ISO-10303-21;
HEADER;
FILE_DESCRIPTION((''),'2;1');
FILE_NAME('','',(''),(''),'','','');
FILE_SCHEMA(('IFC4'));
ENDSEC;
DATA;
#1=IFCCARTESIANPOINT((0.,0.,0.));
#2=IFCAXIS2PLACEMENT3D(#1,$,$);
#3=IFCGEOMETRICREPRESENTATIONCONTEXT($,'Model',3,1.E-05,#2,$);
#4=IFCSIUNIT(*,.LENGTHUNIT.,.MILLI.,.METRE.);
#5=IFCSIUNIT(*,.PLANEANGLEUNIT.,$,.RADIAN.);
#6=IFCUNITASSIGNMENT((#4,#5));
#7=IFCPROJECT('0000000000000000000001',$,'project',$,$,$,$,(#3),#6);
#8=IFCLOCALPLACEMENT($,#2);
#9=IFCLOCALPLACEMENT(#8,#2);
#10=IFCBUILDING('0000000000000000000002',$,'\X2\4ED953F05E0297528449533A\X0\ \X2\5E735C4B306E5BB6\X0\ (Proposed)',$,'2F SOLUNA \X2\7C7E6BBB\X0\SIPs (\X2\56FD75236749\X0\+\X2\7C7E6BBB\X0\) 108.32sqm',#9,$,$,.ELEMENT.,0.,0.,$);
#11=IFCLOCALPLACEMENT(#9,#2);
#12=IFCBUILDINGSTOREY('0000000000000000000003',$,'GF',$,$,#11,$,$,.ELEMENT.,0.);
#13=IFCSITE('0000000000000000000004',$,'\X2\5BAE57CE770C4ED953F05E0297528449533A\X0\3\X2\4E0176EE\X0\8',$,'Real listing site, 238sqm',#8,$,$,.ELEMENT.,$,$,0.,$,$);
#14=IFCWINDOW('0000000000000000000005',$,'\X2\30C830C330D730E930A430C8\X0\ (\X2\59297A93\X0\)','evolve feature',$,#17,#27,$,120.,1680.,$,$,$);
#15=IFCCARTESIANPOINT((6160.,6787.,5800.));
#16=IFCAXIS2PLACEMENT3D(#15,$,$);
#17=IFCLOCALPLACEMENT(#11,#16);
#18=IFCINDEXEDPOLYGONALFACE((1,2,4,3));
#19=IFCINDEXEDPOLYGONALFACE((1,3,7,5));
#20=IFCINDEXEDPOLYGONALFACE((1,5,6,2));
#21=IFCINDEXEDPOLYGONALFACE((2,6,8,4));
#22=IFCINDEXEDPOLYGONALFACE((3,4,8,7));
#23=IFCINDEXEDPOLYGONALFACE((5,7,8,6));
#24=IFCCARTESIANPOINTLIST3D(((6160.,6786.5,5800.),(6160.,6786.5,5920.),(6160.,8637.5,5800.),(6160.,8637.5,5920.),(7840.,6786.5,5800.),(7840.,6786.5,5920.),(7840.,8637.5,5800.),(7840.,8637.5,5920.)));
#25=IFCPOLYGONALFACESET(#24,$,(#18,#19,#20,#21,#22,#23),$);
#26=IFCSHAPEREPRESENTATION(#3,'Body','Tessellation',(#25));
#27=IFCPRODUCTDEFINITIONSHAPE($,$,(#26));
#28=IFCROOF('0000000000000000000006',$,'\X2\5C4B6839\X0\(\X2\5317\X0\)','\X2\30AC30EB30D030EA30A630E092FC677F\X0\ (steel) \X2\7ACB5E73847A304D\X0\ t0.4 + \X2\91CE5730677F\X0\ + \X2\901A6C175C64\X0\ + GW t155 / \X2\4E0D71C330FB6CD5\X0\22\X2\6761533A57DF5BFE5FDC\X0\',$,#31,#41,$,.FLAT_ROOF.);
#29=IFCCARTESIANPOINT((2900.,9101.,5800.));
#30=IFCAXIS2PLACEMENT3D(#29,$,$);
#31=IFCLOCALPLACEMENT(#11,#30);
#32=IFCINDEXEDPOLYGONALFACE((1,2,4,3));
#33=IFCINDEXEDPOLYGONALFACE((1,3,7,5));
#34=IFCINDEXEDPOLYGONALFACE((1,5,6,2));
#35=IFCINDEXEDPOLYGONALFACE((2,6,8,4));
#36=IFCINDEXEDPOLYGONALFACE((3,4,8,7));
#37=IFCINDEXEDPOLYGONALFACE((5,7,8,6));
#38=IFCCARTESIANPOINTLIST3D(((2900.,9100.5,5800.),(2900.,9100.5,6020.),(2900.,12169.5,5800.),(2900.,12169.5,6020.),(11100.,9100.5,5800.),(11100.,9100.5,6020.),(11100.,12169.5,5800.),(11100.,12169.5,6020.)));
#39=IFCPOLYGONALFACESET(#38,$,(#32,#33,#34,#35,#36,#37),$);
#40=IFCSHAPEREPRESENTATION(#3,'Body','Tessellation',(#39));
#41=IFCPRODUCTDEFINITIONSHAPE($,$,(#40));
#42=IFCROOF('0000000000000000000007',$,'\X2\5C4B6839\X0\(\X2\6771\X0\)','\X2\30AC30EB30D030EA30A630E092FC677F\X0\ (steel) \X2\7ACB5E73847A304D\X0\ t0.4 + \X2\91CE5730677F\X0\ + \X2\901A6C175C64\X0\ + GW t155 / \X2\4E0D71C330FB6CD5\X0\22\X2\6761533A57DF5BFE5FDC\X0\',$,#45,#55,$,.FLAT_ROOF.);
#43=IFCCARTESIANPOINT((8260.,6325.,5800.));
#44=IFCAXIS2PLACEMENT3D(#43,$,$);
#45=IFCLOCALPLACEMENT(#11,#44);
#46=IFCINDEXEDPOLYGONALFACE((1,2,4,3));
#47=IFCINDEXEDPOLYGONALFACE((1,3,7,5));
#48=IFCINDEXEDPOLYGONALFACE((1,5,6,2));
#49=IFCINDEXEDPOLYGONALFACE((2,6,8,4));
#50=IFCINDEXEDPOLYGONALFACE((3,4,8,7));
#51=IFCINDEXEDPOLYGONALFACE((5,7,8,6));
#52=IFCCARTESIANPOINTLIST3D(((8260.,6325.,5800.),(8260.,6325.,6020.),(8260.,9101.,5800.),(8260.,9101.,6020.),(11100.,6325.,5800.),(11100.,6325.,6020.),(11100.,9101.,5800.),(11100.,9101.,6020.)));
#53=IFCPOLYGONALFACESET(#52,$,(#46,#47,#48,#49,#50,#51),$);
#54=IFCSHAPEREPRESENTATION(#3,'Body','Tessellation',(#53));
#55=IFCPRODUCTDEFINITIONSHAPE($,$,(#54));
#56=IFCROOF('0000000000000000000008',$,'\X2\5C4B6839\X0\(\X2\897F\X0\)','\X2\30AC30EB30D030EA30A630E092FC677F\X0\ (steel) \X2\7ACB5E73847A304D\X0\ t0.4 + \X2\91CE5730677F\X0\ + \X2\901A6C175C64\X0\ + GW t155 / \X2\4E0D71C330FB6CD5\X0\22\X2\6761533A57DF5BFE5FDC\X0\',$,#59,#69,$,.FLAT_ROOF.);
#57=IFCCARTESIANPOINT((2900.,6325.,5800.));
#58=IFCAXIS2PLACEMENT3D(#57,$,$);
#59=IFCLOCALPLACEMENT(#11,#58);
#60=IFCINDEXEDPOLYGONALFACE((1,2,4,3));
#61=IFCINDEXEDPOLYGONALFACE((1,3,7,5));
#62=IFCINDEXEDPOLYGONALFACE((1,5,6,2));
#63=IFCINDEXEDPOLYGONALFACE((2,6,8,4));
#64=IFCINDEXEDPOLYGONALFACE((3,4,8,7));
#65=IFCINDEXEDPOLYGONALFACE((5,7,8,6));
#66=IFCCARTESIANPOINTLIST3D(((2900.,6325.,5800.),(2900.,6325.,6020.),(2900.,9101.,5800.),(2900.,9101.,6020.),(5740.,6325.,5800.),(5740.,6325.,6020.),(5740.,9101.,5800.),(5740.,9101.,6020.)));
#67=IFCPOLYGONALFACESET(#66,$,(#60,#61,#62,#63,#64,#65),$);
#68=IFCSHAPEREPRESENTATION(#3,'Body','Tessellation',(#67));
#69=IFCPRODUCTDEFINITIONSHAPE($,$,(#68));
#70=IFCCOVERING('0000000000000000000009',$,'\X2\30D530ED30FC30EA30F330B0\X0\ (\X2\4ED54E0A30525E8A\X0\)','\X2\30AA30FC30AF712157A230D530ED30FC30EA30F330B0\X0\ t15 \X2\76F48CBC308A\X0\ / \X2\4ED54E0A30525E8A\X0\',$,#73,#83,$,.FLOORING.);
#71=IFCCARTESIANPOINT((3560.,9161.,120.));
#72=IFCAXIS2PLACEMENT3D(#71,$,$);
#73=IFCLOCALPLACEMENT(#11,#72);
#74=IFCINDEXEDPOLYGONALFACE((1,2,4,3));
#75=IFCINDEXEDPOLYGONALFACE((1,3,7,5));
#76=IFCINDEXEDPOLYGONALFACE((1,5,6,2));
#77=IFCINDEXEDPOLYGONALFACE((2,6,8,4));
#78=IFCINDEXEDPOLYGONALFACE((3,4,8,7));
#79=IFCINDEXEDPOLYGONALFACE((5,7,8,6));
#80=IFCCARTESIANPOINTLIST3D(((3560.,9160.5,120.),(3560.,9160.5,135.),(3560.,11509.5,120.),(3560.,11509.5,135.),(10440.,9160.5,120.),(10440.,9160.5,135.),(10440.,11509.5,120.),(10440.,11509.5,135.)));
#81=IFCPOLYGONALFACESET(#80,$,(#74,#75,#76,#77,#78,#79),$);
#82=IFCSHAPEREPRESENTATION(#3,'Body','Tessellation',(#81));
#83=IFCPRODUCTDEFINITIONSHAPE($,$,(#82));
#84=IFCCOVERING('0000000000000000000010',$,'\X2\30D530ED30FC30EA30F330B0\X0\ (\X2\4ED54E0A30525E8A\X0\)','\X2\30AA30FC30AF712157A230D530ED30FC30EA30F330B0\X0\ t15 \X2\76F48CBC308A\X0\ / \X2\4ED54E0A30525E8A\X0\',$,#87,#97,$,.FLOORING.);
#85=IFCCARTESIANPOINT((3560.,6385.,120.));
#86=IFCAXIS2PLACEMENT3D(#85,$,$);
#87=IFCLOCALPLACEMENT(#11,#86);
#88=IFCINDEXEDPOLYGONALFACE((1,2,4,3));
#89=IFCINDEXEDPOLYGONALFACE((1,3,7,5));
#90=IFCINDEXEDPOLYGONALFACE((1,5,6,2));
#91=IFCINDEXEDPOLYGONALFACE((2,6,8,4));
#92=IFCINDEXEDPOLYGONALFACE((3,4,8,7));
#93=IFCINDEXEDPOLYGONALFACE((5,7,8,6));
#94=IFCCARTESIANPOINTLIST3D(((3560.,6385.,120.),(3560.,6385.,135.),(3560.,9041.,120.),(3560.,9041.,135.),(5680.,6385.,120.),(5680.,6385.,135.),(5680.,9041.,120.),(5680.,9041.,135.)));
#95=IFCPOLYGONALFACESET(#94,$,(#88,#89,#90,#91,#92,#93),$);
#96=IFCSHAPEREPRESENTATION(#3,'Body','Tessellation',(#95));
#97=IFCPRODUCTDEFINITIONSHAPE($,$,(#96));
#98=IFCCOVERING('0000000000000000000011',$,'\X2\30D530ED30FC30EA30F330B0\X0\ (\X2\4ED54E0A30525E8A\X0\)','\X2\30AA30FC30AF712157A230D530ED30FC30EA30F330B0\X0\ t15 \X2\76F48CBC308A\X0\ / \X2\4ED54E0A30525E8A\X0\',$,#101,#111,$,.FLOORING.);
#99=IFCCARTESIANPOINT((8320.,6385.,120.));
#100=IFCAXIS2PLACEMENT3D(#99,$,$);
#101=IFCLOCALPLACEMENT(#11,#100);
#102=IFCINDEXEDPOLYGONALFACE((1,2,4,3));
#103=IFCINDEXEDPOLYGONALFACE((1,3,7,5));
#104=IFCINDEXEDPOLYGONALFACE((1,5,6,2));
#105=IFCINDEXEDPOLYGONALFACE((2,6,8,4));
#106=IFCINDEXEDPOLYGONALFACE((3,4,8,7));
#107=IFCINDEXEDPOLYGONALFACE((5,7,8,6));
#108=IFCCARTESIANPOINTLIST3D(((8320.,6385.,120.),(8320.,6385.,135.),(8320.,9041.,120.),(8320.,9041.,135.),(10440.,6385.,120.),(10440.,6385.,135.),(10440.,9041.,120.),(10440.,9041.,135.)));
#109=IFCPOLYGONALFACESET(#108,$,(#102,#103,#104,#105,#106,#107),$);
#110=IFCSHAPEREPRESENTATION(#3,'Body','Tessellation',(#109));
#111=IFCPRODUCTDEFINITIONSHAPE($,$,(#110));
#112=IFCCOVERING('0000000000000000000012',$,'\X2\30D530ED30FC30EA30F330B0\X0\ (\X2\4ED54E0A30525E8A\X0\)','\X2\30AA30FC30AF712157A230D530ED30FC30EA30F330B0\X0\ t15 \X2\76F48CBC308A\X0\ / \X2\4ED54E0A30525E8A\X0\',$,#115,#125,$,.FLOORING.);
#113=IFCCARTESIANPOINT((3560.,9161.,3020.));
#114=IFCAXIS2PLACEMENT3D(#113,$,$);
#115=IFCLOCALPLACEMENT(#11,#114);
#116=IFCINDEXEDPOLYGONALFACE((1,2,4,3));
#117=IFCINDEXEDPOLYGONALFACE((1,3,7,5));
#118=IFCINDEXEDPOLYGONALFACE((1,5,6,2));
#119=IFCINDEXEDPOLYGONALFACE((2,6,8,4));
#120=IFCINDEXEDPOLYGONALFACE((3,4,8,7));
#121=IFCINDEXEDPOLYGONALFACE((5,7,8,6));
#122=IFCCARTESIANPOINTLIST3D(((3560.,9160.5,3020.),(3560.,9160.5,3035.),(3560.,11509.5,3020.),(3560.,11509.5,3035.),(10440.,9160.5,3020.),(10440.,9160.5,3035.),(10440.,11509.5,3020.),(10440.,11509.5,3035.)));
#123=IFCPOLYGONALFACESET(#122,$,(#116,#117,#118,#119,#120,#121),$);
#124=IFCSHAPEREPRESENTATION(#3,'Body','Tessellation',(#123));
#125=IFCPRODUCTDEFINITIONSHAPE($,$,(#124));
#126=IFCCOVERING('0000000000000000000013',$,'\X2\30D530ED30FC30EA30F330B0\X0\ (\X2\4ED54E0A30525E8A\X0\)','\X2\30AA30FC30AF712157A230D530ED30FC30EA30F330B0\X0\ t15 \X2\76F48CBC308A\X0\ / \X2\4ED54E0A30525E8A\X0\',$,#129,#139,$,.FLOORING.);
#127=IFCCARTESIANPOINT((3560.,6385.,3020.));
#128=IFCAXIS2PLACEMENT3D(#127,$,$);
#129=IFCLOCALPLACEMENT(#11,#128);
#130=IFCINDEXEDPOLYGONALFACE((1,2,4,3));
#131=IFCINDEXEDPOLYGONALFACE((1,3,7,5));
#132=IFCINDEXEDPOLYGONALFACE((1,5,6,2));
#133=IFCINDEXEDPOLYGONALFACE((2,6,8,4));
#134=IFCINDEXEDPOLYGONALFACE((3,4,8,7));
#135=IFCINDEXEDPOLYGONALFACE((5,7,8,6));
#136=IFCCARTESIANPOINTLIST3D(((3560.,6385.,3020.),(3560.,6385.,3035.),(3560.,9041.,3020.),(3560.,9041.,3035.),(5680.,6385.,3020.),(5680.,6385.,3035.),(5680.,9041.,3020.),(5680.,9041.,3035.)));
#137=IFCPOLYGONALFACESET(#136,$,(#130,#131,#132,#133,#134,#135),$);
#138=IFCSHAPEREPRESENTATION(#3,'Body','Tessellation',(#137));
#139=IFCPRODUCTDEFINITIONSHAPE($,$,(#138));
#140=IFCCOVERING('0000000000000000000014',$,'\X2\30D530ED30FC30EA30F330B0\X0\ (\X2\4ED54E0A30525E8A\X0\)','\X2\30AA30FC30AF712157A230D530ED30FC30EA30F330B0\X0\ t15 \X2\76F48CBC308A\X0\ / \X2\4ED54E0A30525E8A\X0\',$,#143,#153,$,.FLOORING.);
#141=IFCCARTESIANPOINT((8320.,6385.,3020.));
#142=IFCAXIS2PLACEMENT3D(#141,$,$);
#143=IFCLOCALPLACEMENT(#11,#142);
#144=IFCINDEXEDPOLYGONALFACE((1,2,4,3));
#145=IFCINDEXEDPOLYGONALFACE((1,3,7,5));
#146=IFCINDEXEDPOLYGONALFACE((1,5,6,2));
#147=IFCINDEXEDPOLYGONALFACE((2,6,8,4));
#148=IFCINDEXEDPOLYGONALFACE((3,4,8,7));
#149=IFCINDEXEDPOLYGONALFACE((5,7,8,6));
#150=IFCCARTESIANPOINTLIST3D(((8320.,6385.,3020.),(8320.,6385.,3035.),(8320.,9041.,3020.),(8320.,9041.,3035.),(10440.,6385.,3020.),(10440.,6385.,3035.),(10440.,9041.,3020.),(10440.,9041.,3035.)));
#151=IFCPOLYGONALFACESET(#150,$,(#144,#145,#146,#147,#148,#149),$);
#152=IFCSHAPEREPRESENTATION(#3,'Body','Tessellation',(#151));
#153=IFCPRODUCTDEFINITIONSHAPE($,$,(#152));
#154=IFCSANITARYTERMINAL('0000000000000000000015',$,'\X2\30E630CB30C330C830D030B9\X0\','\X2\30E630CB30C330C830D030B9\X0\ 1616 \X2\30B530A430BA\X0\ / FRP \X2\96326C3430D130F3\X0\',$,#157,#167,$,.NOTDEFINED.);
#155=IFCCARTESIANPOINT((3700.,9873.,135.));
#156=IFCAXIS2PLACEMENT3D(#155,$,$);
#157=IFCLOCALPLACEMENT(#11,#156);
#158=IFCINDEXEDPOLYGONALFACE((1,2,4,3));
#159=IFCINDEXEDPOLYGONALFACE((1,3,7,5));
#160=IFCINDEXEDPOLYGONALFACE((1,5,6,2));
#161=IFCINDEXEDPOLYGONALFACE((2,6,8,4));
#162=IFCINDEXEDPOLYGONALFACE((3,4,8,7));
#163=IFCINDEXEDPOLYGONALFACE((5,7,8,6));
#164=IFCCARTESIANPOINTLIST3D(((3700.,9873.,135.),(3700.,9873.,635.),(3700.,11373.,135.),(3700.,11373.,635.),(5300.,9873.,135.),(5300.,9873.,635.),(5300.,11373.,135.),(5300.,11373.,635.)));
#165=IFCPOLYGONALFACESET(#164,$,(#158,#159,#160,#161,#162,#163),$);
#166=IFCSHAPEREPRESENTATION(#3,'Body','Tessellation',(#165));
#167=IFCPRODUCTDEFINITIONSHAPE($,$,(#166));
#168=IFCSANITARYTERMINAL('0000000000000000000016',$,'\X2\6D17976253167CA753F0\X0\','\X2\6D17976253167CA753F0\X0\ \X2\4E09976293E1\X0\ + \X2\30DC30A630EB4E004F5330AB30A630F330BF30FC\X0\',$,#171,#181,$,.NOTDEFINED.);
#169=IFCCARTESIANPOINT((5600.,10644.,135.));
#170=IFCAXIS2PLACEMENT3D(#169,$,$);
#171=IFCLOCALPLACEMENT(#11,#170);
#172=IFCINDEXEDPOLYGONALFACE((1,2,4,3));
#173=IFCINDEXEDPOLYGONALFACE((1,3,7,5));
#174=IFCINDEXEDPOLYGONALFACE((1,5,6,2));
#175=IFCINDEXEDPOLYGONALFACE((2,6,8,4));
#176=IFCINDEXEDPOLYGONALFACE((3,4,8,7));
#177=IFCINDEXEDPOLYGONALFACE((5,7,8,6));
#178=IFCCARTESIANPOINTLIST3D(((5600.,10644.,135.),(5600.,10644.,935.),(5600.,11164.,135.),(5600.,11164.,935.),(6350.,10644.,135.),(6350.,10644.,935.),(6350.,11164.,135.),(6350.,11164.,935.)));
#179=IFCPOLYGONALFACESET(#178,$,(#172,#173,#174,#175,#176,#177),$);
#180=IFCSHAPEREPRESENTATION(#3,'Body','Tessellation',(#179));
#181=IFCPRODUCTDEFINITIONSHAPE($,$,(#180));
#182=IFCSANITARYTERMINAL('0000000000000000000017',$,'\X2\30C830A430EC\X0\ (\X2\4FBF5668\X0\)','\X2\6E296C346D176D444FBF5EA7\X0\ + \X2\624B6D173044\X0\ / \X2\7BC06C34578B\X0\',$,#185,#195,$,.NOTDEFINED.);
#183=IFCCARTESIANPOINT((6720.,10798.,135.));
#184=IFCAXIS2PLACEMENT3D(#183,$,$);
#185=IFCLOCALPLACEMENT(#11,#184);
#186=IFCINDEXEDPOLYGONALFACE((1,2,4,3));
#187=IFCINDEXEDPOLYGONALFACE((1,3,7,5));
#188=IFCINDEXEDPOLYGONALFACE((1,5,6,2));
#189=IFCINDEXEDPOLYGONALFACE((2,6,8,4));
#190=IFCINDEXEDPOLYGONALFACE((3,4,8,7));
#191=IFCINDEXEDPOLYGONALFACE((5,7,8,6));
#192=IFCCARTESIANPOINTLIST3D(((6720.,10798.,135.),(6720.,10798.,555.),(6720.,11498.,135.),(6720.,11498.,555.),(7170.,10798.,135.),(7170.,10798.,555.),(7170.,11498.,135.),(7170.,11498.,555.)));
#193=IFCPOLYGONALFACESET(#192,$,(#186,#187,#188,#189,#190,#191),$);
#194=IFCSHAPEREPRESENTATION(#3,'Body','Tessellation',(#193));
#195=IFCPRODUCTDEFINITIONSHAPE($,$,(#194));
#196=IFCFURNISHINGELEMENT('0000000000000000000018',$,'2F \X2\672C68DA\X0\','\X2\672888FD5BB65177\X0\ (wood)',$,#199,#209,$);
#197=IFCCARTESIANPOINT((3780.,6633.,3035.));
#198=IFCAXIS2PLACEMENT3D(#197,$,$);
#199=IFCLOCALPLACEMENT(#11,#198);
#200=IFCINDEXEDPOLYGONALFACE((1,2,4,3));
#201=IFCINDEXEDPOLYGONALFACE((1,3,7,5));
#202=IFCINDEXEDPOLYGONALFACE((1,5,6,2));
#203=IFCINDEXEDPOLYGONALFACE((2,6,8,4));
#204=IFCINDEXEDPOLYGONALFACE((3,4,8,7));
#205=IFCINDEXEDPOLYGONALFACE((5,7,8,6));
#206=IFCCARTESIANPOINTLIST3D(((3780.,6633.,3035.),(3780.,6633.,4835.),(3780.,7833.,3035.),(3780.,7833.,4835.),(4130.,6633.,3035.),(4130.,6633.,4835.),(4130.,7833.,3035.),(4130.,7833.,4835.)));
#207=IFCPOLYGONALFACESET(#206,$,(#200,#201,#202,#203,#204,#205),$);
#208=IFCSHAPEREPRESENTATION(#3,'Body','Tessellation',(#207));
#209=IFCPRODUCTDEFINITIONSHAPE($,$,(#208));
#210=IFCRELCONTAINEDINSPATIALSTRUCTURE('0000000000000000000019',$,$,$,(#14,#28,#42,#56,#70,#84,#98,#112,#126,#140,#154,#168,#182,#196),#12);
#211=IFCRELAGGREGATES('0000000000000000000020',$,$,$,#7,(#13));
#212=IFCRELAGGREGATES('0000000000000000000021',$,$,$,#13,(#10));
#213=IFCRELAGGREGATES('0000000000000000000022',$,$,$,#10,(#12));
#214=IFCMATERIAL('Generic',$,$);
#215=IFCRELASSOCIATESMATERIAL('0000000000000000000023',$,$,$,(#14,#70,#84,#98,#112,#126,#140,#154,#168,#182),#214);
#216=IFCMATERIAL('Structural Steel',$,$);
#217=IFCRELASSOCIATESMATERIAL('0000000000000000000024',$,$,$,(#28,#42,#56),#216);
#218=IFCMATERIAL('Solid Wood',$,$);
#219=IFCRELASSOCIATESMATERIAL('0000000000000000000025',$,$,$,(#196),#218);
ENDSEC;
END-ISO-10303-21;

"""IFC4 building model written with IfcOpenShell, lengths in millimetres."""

from ifc_helpers import new_model, si_unit, frame, frame_2d, origin, place, context, project, spatial, rectangle, extrude, material, element, save


model = new_model("IFC4")

# Units and contexts
model_context = context("Model", 3, precision=1e-05, world=origin())
ifc_project = project(units=[si_unit("LENGTHUNIT", "METRE", prefix="MILLI"), si_unit("PLANEANGLEUNIT", "RADIAN")], contexts=[model_context])

# Site, building, storey
site_placement = place(None, origin())
site = spatial("IfcSite", under=ifc_project, at=site_placement, Name="宮城県仙台市青葉区3丁目8", ObjectType="Real listing site, 238sqm", CompositionType="ELEMENT", RefElevation=0.0)
building_placement = place(site_placement, origin())
building = spatial("IfcBuilding", under=site, at=building_placement, Name="仙台市青葉区 平屋の家 (Proposed)", ObjectType="2F SOLUNA 籾殻SIPs (国産杉+籾殻) 108.32sqm", CompositionType="ELEMENT", ElevationOfRefHeight=0.0, ElevationOfTerrain=0.0)
storey_placement = place(building_placement, origin())
storey = spatial("IfcBuildingStorey", under=building, at=storey_placement, Name="GF", CompositionType="ELEMENT", Elevation=0.0)

# Shared definitions
ifc_material_1 = material(Name="Solid Wood")

# Window
ifc_material_2 = material(Name="Generic")
window_1_placement = place(storey_placement, frame((6160.0, 6787.0, 5800.0)))
element("IfcWindow", 1, at=window_1_placement, inside=storey, material=ifc_material_2, Name="トップライト (天窓)", Description="evolve feature", OverallHeight=120.0, OverallWidth=1680.0, context=model_context, shape_type="SweptSolid", body=[
    extrude(rectangle(XDim=1680.0, YDim=1851.0, at=frame_2d((840.0, 925.0))), frame((6160.0, 6787.0, 5800.0)), (0.0, 0.0, 1.0), 120.0),
])

# Roofs
ifc_material_3 = material(Name="Structural Steel")
roof_1_placement = place(storey_placement, frame((2900.0, 9101.0, 5800.0)))
element("IfcRoof", 2, at=roof_1_placement, inside=storey, material=ifc_material_3, Name="屋根(北)", Description="ガルバリウム鋼板 (steel) 立平葺き t0.4 + 野地板 + 通気層 + GW t155 / 不燃・法22条区域対応", PredefinedType="FLAT_ROOF", context=model_context, shape_type="SweptSolid", body=[
    extrude(rectangle(XDim=8200.0, YDim=3069.0, at=frame_2d((4100.0, 1534.0))), frame((2900.0, 9101.0, 5800.0)), (0.0, 0.0, 1.0), 220.0),
])
roof_2_placement = place(storey_placement, frame((8260.0, 6325.0, 5800.0)))
element("IfcRoof", 3, at=roof_2_placement, inside=storey, material=ifc_material_3, Name="屋根(東)", Description="ガルバリウム鋼板 (steel) 立平葺き t0.4 + 野地板 + 通気層 + GW t155 / 不燃・法22条区域対応", PredefinedType="FLAT_ROOF", context=model_context, shape_type="SweptSolid", body=[
    extrude(rectangle(XDim=2840.0, YDim=2776.0, at=frame_2d((1420.0, 1388.0))), frame((8260.0, 6325.0, 5800.0)), (0.0, 0.0, 1.0), 220.0),
])
roof_3_placement = place(storey_placement, frame((2900.0, 6325.0, 5800.0)))
element("IfcRoof", 4, at=roof_3_placement, inside=storey, material=ifc_material_3, Name="屋根(西)", Description="ガルバリウム鋼板 (steel) 立平葺き t0.4 + 野地板 + 通気層 + GW t155 / 不燃・法22条区域対応", PredefinedType="FLAT_ROOF", context=model_context, shape_type="SweptSolid", body=[
    extrude(rectangle(XDim=2840.0, YDim=2776.0, at=frame_2d((1420.0, 1388.0))), frame((2900.0, 6325.0, 5800.0)), (0.0, 0.0, 1.0), 220.0),
])

# Coverings
covering_1_placement = place(storey_placement, frame((3560.0, 9161.0, 120.0)))
element("IfcCovering", 5, at=covering_1_placement, inside=storey, material=ifc_material_2, Name="フローリング (仕上げ床)", Description="オーク無垢フローリング t15 直貼り / 仕上げ床", PredefinedType="FLOORING", context=model_context, shape_type="SweptSolid", body=[
    extrude(rectangle(XDim=6880.0, YDim=2349.0, at=frame_2d((3440.0, 1174.0))), frame((3560.0, 9161.0, 120.0)), (0.0, 0.0, 1.0), 15.0),
])
covering_2_placement = place(storey_placement, frame((3560.0, 6385.0, 120.0)))
element("IfcCovering", 6, at=covering_2_placement, inside=storey, material=ifc_material_2, Name="フローリング (仕上げ床)", Description="オーク無垢フローリング t15 直貼り / 仕上げ床", PredefinedType="FLOORING", context=model_context, shape_type="SweptSolid", body=[
    extrude(rectangle(XDim=2120.0, YDim=2656.0, at=frame_2d((1060.0, 1328.0))), frame((3560.0, 6385.0, 120.0)), (0.0, 0.0, 1.0), 15.0),
])
covering_3_placement = place(storey_placement, frame((8320.0, 6385.0, 120.0)))
element("IfcCovering", 7, at=covering_3_placement, inside=storey, material=ifc_material_2, Name="フローリング (仕上げ床)", Description="オーク無垢フローリング t15 直貼り / 仕上げ床", PredefinedType="FLOORING", context=model_context, shape_type="SweptSolid", body=[
    extrude(rectangle(XDim=2120.0, YDim=2656.0, at=frame_2d((1060.0, 1328.0))), frame((8320.0, 6385.0, 120.0)), (0.0, 0.0, 1.0), 15.0),
])
covering_4_placement = place(storey_placement, frame((3560.0, 9161.0, 3020.0)))
element("IfcCovering", 8, at=covering_4_placement, inside=storey, material=ifc_material_2, Name="フローリング (仕上げ床)", Description="オーク無垢フローリング t15 直貼り / 仕上げ床", PredefinedType="FLOORING", context=model_context, shape_type="SweptSolid", body=[
    extrude(rectangle(XDim=6880.0, YDim=2349.0, at=frame_2d((3440.0, 1174.0))), frame((3560.0, 9161.0, 3020.0)), (0.0, 0.0, 1.0), 15.0),
])
covering_5_placement = place(storey_placement, frame((3560.0, 6385.0, 3020.0)))
element("IfcCovering", 9, at=covering_5_placement, inside=storey, material=ifc_material_2, Name="フローリング (仕上げ床)", Description="オーク無垢フローリング t15 直貼り / 仕上げ床", PredefinedType="FLOORING", context=model_context, shape_type="SweptSolid", body=[
    extrude(rectangle(XDim=2120.0, YDim=2656.0, at=frame_2d((1060.0, 1328.0))), frame((3560.0, 6385.0, 3020.0)), (0.0, 0.0, 1.0), 15.0),
])
covering_6_placement = place(storey_placement, frame((8320.0, 6385.0, 3020.0)))
element("IfcCovering", 10, at=covering_6_placement, inside=storey, material=ifc_material_2, Name="フローリング (仕上げ床)", Description="オーク無垢フローリング t15 直貼り / 仕上げ床", PredefinedType="FLOORING", context=model_context, shape_type="SweptSolid", body=[
    extrude(rectangle(XDim=2120.0, YDim=2656.0, at=frame_2d((1060.0, 1328.0))), frame((8320.0, 6385.0, 3020.0)), (0.0, 0.0, 1.0), 15.0),
])

# Sanitary terminals
sanitary_terminal_1_placement = place(storey_placement, frame((3700.0, 9873.0, 135.0)))
element("IfcSanitaryTerminal", 11, at=sanitary_terminal_1_placement, inside=storey, material=ifc_material_2, Name="ユニットバス", Description="ユニットバス 1616 サイズ / FRP 防水パン", PredefinedType="NOTDEFINED", context=model_context, shape_type="SweptSolid", body=[
    extrude(rectangle(XDim=1600.0, YDim=1500.0, at=frame_2d((800.0, 750.0))), frame((3700.0, 9873.0, 135.0)), (0.0, 0.0, 1.0), 500.0),
])
sanitary_terminal_2_placement = place(storey_placement, frame((5600.0, 10644.0, 135.0)))
element("IfcSanitaryTerminal", 12, at=sanitary_terminal_2_placement, inside=storey, material=ifc_material_2, Name="洗面化粧台", Description="洗面化粧台 三面鏡 + ボウル一体カウンター", PredefinedType="NOTDEFINED", context=model_context, shape_type="SweptSolid", body=[
    extrude(rectangle(XDim=750.0, YDim=520.0, at=frame_2d((375.0, 260.0))), frame((5600.0, 10644.0, 135.0)), (0.0, 0.0, 1.0), 800.0),
])
sanitary_terminal_3_placement = place(storey_placement, frame((6720.0, 10798.0, 135.0)))
element("IfcSanitaryTerminal", 13, at=sanitary_terminal_3_placement, inside=storey, material=ifc_material_2, Name="トイレ (便器)", Description="温水洗浄便座 + 手洗い / 節水型", PredefinedType="NOTDEFINED", context=model_context, shape_type="SweptSolid", body=[
    extrude(rectangle(XDim=450.0, YDim=700.0, at=frame_2d((225.0, 350.0))), frame((6720.0, 10798.0, 135.0)), (0.0, 0.0, 1.0), 420.0),
])

# Furnishing element
furnishing_placement = place(storey_placement, frame((3780.0, 6633.0, 3035.0)))
element("IfcFurnishingElement", 14, at=furnishing_placement, inside=storey, material=ifc_material_1, Name="2F 本棚", Description="木製家具 (wood)", context=model_context, shape_type="SweptSolid", body=[
    extrude(rectangle(XDim=350.0, YDim=1200.0, at=frame_2d((175.0, 600.0))), frame((3780.0, 6633.0, 3035.0)), (0.0, 0.0, 1.0), 1800.0),
])

save(model, "model.ifc")
